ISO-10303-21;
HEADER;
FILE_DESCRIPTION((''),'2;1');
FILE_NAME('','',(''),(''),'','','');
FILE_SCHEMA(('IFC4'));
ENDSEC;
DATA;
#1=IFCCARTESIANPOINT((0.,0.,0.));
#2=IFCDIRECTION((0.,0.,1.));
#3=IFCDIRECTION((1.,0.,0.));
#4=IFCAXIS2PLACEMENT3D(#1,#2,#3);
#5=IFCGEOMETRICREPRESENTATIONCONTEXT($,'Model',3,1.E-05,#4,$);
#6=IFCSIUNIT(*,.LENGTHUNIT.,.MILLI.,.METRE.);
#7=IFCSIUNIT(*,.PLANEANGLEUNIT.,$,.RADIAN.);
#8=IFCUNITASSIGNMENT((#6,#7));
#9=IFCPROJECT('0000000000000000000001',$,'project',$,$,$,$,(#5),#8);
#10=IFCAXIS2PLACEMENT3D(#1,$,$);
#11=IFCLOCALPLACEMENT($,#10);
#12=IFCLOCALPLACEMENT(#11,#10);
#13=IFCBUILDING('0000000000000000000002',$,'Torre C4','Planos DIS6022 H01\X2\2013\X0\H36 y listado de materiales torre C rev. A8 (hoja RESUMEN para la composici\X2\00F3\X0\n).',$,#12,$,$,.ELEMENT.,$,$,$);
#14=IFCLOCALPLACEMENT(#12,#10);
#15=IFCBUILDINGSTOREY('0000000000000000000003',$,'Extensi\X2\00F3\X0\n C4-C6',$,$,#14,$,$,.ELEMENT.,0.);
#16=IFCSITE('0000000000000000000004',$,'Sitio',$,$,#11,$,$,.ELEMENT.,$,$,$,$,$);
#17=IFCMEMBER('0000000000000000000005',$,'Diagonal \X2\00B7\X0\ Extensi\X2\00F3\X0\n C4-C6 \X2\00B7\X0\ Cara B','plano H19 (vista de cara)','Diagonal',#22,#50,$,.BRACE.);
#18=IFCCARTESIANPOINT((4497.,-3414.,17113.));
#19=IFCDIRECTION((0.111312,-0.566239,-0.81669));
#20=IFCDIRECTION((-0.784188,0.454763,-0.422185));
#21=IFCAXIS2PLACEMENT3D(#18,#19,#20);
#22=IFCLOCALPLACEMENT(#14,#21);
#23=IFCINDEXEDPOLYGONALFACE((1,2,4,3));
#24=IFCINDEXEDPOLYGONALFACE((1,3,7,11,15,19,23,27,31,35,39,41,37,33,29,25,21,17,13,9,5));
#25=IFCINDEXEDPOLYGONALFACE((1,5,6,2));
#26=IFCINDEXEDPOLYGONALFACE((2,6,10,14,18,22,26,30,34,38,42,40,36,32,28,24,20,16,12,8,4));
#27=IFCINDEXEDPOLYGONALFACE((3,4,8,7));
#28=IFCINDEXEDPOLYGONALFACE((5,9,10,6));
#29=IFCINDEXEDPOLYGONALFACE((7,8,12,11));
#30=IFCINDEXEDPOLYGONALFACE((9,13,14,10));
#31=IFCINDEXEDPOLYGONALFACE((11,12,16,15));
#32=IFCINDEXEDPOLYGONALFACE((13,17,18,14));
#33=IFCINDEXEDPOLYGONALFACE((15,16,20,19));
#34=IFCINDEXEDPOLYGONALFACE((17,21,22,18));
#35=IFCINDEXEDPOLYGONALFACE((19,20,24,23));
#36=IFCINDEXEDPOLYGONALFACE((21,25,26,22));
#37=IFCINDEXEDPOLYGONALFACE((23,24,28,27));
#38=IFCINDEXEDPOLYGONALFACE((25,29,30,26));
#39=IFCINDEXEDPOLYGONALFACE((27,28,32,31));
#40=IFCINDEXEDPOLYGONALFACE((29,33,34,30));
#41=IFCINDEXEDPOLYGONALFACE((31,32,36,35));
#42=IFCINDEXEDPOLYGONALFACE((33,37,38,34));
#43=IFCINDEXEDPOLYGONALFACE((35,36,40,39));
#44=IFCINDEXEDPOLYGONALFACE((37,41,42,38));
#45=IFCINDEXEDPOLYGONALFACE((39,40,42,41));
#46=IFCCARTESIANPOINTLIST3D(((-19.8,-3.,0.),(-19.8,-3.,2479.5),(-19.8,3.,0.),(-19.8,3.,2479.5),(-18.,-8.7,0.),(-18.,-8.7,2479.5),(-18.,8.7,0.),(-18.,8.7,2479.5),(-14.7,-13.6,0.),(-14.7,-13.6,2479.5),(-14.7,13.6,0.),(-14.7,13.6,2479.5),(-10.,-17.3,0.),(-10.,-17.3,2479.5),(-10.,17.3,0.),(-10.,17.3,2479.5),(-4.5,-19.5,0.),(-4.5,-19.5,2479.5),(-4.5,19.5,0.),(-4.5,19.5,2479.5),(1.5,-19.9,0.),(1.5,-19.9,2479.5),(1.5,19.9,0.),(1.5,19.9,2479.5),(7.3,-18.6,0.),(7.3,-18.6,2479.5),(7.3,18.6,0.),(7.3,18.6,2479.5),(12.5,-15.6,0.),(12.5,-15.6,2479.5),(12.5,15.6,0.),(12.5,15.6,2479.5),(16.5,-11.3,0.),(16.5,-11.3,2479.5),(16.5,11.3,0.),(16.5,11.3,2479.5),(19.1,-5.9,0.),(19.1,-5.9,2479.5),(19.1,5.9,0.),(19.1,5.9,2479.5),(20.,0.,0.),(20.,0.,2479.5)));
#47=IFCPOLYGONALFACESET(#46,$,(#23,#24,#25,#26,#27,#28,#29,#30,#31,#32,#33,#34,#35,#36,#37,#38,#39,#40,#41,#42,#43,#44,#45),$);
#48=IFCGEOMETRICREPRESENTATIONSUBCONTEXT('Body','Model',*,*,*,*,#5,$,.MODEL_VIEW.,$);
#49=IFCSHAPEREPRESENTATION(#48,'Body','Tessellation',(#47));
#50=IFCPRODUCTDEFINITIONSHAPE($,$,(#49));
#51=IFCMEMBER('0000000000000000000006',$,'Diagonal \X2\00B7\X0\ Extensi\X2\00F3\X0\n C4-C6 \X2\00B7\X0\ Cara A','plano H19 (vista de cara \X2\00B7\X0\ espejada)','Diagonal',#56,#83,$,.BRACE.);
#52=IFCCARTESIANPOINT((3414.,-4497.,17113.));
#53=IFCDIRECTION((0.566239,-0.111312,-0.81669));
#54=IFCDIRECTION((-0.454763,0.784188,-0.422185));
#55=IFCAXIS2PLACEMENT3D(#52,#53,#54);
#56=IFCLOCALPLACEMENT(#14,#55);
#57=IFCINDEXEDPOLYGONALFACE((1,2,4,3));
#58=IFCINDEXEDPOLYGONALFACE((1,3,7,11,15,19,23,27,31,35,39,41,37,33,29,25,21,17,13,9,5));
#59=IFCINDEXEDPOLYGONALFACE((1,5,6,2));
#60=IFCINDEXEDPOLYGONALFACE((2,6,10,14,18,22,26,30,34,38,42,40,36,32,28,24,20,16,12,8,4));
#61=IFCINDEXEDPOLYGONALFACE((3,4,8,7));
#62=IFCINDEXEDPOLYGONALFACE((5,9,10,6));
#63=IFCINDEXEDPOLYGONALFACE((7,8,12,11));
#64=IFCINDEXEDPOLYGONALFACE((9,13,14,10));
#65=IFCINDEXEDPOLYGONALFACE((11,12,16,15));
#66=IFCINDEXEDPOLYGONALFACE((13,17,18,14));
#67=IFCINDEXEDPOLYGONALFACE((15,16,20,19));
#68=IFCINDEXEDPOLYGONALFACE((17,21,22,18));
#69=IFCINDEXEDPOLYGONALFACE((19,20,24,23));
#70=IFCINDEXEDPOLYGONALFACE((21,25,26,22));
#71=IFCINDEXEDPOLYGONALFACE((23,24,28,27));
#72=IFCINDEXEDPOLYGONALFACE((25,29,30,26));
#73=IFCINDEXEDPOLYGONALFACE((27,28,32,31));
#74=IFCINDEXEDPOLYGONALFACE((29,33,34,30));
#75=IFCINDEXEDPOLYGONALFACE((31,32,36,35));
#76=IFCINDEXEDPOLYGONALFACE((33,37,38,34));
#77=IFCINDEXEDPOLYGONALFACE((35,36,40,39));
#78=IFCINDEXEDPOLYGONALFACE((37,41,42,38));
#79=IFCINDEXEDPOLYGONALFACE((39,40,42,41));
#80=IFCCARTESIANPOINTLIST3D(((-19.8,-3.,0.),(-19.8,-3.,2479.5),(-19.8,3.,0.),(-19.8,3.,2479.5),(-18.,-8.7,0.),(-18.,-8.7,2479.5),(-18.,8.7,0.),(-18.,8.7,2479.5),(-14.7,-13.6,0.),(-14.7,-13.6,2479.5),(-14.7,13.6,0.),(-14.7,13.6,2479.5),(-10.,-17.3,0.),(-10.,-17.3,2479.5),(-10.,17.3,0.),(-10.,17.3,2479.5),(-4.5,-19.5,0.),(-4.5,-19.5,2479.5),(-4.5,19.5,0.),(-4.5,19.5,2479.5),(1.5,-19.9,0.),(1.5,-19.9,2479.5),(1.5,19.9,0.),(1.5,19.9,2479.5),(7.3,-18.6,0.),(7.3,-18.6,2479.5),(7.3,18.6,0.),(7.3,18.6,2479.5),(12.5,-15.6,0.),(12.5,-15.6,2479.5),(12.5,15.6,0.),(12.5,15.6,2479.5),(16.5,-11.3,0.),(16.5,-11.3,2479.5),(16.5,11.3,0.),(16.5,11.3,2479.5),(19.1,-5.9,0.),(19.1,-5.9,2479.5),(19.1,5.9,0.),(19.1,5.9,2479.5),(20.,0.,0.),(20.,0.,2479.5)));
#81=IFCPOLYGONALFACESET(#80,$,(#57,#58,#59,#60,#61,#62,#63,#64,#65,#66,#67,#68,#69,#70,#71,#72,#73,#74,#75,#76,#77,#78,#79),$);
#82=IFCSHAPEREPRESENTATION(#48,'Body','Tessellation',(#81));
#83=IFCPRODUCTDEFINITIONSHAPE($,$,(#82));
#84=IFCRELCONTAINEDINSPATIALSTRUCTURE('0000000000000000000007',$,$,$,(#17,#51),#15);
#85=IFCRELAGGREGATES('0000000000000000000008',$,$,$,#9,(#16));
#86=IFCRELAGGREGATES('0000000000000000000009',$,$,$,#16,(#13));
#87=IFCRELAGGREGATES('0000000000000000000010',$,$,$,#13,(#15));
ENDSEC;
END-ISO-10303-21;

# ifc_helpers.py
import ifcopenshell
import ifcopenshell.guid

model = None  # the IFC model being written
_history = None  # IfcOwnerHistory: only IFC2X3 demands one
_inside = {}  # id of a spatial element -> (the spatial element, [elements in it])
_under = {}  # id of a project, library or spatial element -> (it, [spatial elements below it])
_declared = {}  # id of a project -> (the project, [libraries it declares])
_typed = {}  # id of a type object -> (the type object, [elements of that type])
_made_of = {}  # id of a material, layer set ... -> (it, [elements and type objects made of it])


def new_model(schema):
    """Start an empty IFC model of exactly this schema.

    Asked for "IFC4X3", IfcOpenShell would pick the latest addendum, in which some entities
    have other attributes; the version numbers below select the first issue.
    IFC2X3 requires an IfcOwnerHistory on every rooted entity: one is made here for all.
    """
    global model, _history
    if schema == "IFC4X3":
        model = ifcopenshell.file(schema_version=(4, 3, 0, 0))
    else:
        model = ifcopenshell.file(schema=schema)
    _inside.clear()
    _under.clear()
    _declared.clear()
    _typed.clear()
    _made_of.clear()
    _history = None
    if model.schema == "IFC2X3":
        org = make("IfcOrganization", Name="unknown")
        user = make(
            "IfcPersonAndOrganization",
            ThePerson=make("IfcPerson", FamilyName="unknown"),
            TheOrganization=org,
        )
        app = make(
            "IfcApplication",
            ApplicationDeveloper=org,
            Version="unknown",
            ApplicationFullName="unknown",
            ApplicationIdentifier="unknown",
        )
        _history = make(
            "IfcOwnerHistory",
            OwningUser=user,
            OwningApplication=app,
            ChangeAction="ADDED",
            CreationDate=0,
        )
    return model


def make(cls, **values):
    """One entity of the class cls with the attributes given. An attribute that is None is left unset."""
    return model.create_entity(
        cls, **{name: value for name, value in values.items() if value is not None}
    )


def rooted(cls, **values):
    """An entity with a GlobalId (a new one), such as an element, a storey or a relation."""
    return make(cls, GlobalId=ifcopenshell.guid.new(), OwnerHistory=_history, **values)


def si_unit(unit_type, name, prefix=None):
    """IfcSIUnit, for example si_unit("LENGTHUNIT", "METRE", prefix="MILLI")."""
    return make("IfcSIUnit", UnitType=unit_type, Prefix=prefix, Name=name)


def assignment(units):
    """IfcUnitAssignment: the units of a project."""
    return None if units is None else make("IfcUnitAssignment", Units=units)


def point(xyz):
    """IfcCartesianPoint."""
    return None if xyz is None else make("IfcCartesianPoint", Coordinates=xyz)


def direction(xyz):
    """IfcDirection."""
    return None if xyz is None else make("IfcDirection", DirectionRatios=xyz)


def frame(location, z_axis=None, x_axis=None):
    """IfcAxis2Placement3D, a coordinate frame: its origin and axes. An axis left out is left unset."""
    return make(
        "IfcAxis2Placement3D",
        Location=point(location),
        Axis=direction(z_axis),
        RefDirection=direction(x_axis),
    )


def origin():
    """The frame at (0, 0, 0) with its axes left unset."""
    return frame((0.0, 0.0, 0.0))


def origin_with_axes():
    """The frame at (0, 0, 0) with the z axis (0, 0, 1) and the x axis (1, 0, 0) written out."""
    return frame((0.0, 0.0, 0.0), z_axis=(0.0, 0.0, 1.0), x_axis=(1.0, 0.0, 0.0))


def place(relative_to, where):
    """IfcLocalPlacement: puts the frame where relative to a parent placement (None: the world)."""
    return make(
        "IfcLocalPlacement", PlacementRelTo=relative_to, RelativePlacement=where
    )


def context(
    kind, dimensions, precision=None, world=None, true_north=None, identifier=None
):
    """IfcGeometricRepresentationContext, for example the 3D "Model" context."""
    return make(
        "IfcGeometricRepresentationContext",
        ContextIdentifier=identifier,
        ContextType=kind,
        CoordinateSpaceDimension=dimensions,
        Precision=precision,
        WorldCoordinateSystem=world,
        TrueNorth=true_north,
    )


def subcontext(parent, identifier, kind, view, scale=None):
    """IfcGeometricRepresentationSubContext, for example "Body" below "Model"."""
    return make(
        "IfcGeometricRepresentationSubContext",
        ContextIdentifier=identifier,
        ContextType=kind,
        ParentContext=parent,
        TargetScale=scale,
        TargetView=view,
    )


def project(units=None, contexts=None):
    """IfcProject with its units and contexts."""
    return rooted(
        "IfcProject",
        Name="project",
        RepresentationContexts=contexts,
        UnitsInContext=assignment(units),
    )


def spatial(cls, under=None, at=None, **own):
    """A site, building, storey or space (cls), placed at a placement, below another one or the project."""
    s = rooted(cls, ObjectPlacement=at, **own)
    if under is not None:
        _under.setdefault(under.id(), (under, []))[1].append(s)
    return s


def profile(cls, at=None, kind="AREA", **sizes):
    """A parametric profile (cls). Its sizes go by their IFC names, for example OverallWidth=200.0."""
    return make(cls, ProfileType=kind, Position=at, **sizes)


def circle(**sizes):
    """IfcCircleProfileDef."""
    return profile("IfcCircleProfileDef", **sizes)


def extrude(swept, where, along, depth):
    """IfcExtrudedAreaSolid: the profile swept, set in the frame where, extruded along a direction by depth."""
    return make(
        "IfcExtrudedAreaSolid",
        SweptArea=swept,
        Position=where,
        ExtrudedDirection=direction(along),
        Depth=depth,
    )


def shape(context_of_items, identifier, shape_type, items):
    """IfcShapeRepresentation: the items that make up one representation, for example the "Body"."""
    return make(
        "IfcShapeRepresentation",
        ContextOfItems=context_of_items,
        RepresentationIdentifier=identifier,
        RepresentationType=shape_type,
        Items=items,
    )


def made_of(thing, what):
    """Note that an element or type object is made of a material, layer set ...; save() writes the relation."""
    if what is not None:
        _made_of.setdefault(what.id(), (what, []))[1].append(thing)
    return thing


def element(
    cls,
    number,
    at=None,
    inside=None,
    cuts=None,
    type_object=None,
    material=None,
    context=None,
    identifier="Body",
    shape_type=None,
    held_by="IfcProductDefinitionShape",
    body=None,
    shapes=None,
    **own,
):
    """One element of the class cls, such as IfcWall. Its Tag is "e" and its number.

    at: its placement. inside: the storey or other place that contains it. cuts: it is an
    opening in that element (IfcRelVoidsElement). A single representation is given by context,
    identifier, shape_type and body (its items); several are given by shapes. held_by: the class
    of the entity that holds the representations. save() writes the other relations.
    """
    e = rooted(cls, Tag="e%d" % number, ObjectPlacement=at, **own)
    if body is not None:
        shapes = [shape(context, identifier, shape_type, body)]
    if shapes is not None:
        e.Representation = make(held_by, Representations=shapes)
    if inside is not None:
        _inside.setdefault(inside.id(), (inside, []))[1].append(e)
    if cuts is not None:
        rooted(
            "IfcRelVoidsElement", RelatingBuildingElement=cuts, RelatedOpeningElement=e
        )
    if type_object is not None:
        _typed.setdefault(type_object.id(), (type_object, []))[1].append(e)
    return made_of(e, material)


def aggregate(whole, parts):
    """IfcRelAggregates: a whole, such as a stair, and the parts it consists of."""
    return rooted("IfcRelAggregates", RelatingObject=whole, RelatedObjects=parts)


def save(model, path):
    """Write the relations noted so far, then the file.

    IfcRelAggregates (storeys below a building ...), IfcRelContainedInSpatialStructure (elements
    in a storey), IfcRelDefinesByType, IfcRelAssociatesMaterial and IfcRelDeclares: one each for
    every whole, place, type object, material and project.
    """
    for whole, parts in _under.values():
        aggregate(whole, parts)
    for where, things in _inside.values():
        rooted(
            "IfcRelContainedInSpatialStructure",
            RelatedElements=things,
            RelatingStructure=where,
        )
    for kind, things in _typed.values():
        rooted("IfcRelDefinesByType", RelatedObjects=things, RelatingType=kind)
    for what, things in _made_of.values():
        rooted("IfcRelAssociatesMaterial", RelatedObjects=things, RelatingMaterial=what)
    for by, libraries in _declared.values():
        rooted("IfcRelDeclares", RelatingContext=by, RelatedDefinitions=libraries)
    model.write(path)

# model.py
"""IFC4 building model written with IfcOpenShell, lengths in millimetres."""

from ifc_helpers import new_model, si_unit, frame, origin, origin_with_axes, place, context, subcontext, project, spatial, circle, extrude, element, save


model = new_model("IFC4")

# Units and contexts
model_context = context("Model", 3, precision=1e-05, world=origin_with_axes())
body_context = subcontext(model_context, "Body", "Model", "MODEL_VIEW")
ifc_project = project(units=[si_unit("LENGTHUNIT", "METRE", prefix="MILLI"), si_unit("PLANEANGLEUNIT", "RADIAN")], contexts=[model_context])

# Site, building, storey
site_placement = place(None, origin())
site = spatial("IfcSite", under=ifc_project, at=site_placement, Name="Sitio", CompositionType="ELEMENT")
building_placement = place(site_placement, origin())
building = spatial("IfcBuilding", under=site, at=building_placement, Name="Torre C4", Description="Planos DIS6022 H01–H36 y listado de materiales torre C rev. A8 (hoja RESUMEN para la composición).", CompositionType="ELEMENT")
storey_placement = place(building_placement, origin())
storey = spatial("IfcBuildingStorey", under=building, at=storey_placement, Name="Extensión C4-C6", CompositionType="ELEMENT", Elevation=0.0)

# Members
for number, where, z_axis, x_axis, name, description in (
    (1, (4497.0, -3414.0, 17113.0), (0.111312, -0.566239, -0.81669), (-0.784188, 0.454763, -0.422185), "Diagonal · Extensión C4-C6 · Cara B", "plano H19 (vista de cara)"),
    (2, (3414.0, -4497.0, 17113.0), (0.566239, -0.111312, -0.81669), (-0.454763, 0.784188, -0.422185), "Diagonal · Extensión C4-C6 · Cara A", "plano H19 (vista de cara · espejada)"),
):
    element("IfcMember", number, at=place(storey_placement, frame(where, z_axis=z_axis, x_axis=x_axis)), inside=storey, Name=name, Description=description, ObjectType="Diagonal", PredefinedType="BRACE", context=body_context, shape_type="SweptSolid", body=[
        extrude(circle(Radius=20.0), None, (0.0, 0.0, 1.0), 2479.5),
    ])

save(model, "model.ifc")
